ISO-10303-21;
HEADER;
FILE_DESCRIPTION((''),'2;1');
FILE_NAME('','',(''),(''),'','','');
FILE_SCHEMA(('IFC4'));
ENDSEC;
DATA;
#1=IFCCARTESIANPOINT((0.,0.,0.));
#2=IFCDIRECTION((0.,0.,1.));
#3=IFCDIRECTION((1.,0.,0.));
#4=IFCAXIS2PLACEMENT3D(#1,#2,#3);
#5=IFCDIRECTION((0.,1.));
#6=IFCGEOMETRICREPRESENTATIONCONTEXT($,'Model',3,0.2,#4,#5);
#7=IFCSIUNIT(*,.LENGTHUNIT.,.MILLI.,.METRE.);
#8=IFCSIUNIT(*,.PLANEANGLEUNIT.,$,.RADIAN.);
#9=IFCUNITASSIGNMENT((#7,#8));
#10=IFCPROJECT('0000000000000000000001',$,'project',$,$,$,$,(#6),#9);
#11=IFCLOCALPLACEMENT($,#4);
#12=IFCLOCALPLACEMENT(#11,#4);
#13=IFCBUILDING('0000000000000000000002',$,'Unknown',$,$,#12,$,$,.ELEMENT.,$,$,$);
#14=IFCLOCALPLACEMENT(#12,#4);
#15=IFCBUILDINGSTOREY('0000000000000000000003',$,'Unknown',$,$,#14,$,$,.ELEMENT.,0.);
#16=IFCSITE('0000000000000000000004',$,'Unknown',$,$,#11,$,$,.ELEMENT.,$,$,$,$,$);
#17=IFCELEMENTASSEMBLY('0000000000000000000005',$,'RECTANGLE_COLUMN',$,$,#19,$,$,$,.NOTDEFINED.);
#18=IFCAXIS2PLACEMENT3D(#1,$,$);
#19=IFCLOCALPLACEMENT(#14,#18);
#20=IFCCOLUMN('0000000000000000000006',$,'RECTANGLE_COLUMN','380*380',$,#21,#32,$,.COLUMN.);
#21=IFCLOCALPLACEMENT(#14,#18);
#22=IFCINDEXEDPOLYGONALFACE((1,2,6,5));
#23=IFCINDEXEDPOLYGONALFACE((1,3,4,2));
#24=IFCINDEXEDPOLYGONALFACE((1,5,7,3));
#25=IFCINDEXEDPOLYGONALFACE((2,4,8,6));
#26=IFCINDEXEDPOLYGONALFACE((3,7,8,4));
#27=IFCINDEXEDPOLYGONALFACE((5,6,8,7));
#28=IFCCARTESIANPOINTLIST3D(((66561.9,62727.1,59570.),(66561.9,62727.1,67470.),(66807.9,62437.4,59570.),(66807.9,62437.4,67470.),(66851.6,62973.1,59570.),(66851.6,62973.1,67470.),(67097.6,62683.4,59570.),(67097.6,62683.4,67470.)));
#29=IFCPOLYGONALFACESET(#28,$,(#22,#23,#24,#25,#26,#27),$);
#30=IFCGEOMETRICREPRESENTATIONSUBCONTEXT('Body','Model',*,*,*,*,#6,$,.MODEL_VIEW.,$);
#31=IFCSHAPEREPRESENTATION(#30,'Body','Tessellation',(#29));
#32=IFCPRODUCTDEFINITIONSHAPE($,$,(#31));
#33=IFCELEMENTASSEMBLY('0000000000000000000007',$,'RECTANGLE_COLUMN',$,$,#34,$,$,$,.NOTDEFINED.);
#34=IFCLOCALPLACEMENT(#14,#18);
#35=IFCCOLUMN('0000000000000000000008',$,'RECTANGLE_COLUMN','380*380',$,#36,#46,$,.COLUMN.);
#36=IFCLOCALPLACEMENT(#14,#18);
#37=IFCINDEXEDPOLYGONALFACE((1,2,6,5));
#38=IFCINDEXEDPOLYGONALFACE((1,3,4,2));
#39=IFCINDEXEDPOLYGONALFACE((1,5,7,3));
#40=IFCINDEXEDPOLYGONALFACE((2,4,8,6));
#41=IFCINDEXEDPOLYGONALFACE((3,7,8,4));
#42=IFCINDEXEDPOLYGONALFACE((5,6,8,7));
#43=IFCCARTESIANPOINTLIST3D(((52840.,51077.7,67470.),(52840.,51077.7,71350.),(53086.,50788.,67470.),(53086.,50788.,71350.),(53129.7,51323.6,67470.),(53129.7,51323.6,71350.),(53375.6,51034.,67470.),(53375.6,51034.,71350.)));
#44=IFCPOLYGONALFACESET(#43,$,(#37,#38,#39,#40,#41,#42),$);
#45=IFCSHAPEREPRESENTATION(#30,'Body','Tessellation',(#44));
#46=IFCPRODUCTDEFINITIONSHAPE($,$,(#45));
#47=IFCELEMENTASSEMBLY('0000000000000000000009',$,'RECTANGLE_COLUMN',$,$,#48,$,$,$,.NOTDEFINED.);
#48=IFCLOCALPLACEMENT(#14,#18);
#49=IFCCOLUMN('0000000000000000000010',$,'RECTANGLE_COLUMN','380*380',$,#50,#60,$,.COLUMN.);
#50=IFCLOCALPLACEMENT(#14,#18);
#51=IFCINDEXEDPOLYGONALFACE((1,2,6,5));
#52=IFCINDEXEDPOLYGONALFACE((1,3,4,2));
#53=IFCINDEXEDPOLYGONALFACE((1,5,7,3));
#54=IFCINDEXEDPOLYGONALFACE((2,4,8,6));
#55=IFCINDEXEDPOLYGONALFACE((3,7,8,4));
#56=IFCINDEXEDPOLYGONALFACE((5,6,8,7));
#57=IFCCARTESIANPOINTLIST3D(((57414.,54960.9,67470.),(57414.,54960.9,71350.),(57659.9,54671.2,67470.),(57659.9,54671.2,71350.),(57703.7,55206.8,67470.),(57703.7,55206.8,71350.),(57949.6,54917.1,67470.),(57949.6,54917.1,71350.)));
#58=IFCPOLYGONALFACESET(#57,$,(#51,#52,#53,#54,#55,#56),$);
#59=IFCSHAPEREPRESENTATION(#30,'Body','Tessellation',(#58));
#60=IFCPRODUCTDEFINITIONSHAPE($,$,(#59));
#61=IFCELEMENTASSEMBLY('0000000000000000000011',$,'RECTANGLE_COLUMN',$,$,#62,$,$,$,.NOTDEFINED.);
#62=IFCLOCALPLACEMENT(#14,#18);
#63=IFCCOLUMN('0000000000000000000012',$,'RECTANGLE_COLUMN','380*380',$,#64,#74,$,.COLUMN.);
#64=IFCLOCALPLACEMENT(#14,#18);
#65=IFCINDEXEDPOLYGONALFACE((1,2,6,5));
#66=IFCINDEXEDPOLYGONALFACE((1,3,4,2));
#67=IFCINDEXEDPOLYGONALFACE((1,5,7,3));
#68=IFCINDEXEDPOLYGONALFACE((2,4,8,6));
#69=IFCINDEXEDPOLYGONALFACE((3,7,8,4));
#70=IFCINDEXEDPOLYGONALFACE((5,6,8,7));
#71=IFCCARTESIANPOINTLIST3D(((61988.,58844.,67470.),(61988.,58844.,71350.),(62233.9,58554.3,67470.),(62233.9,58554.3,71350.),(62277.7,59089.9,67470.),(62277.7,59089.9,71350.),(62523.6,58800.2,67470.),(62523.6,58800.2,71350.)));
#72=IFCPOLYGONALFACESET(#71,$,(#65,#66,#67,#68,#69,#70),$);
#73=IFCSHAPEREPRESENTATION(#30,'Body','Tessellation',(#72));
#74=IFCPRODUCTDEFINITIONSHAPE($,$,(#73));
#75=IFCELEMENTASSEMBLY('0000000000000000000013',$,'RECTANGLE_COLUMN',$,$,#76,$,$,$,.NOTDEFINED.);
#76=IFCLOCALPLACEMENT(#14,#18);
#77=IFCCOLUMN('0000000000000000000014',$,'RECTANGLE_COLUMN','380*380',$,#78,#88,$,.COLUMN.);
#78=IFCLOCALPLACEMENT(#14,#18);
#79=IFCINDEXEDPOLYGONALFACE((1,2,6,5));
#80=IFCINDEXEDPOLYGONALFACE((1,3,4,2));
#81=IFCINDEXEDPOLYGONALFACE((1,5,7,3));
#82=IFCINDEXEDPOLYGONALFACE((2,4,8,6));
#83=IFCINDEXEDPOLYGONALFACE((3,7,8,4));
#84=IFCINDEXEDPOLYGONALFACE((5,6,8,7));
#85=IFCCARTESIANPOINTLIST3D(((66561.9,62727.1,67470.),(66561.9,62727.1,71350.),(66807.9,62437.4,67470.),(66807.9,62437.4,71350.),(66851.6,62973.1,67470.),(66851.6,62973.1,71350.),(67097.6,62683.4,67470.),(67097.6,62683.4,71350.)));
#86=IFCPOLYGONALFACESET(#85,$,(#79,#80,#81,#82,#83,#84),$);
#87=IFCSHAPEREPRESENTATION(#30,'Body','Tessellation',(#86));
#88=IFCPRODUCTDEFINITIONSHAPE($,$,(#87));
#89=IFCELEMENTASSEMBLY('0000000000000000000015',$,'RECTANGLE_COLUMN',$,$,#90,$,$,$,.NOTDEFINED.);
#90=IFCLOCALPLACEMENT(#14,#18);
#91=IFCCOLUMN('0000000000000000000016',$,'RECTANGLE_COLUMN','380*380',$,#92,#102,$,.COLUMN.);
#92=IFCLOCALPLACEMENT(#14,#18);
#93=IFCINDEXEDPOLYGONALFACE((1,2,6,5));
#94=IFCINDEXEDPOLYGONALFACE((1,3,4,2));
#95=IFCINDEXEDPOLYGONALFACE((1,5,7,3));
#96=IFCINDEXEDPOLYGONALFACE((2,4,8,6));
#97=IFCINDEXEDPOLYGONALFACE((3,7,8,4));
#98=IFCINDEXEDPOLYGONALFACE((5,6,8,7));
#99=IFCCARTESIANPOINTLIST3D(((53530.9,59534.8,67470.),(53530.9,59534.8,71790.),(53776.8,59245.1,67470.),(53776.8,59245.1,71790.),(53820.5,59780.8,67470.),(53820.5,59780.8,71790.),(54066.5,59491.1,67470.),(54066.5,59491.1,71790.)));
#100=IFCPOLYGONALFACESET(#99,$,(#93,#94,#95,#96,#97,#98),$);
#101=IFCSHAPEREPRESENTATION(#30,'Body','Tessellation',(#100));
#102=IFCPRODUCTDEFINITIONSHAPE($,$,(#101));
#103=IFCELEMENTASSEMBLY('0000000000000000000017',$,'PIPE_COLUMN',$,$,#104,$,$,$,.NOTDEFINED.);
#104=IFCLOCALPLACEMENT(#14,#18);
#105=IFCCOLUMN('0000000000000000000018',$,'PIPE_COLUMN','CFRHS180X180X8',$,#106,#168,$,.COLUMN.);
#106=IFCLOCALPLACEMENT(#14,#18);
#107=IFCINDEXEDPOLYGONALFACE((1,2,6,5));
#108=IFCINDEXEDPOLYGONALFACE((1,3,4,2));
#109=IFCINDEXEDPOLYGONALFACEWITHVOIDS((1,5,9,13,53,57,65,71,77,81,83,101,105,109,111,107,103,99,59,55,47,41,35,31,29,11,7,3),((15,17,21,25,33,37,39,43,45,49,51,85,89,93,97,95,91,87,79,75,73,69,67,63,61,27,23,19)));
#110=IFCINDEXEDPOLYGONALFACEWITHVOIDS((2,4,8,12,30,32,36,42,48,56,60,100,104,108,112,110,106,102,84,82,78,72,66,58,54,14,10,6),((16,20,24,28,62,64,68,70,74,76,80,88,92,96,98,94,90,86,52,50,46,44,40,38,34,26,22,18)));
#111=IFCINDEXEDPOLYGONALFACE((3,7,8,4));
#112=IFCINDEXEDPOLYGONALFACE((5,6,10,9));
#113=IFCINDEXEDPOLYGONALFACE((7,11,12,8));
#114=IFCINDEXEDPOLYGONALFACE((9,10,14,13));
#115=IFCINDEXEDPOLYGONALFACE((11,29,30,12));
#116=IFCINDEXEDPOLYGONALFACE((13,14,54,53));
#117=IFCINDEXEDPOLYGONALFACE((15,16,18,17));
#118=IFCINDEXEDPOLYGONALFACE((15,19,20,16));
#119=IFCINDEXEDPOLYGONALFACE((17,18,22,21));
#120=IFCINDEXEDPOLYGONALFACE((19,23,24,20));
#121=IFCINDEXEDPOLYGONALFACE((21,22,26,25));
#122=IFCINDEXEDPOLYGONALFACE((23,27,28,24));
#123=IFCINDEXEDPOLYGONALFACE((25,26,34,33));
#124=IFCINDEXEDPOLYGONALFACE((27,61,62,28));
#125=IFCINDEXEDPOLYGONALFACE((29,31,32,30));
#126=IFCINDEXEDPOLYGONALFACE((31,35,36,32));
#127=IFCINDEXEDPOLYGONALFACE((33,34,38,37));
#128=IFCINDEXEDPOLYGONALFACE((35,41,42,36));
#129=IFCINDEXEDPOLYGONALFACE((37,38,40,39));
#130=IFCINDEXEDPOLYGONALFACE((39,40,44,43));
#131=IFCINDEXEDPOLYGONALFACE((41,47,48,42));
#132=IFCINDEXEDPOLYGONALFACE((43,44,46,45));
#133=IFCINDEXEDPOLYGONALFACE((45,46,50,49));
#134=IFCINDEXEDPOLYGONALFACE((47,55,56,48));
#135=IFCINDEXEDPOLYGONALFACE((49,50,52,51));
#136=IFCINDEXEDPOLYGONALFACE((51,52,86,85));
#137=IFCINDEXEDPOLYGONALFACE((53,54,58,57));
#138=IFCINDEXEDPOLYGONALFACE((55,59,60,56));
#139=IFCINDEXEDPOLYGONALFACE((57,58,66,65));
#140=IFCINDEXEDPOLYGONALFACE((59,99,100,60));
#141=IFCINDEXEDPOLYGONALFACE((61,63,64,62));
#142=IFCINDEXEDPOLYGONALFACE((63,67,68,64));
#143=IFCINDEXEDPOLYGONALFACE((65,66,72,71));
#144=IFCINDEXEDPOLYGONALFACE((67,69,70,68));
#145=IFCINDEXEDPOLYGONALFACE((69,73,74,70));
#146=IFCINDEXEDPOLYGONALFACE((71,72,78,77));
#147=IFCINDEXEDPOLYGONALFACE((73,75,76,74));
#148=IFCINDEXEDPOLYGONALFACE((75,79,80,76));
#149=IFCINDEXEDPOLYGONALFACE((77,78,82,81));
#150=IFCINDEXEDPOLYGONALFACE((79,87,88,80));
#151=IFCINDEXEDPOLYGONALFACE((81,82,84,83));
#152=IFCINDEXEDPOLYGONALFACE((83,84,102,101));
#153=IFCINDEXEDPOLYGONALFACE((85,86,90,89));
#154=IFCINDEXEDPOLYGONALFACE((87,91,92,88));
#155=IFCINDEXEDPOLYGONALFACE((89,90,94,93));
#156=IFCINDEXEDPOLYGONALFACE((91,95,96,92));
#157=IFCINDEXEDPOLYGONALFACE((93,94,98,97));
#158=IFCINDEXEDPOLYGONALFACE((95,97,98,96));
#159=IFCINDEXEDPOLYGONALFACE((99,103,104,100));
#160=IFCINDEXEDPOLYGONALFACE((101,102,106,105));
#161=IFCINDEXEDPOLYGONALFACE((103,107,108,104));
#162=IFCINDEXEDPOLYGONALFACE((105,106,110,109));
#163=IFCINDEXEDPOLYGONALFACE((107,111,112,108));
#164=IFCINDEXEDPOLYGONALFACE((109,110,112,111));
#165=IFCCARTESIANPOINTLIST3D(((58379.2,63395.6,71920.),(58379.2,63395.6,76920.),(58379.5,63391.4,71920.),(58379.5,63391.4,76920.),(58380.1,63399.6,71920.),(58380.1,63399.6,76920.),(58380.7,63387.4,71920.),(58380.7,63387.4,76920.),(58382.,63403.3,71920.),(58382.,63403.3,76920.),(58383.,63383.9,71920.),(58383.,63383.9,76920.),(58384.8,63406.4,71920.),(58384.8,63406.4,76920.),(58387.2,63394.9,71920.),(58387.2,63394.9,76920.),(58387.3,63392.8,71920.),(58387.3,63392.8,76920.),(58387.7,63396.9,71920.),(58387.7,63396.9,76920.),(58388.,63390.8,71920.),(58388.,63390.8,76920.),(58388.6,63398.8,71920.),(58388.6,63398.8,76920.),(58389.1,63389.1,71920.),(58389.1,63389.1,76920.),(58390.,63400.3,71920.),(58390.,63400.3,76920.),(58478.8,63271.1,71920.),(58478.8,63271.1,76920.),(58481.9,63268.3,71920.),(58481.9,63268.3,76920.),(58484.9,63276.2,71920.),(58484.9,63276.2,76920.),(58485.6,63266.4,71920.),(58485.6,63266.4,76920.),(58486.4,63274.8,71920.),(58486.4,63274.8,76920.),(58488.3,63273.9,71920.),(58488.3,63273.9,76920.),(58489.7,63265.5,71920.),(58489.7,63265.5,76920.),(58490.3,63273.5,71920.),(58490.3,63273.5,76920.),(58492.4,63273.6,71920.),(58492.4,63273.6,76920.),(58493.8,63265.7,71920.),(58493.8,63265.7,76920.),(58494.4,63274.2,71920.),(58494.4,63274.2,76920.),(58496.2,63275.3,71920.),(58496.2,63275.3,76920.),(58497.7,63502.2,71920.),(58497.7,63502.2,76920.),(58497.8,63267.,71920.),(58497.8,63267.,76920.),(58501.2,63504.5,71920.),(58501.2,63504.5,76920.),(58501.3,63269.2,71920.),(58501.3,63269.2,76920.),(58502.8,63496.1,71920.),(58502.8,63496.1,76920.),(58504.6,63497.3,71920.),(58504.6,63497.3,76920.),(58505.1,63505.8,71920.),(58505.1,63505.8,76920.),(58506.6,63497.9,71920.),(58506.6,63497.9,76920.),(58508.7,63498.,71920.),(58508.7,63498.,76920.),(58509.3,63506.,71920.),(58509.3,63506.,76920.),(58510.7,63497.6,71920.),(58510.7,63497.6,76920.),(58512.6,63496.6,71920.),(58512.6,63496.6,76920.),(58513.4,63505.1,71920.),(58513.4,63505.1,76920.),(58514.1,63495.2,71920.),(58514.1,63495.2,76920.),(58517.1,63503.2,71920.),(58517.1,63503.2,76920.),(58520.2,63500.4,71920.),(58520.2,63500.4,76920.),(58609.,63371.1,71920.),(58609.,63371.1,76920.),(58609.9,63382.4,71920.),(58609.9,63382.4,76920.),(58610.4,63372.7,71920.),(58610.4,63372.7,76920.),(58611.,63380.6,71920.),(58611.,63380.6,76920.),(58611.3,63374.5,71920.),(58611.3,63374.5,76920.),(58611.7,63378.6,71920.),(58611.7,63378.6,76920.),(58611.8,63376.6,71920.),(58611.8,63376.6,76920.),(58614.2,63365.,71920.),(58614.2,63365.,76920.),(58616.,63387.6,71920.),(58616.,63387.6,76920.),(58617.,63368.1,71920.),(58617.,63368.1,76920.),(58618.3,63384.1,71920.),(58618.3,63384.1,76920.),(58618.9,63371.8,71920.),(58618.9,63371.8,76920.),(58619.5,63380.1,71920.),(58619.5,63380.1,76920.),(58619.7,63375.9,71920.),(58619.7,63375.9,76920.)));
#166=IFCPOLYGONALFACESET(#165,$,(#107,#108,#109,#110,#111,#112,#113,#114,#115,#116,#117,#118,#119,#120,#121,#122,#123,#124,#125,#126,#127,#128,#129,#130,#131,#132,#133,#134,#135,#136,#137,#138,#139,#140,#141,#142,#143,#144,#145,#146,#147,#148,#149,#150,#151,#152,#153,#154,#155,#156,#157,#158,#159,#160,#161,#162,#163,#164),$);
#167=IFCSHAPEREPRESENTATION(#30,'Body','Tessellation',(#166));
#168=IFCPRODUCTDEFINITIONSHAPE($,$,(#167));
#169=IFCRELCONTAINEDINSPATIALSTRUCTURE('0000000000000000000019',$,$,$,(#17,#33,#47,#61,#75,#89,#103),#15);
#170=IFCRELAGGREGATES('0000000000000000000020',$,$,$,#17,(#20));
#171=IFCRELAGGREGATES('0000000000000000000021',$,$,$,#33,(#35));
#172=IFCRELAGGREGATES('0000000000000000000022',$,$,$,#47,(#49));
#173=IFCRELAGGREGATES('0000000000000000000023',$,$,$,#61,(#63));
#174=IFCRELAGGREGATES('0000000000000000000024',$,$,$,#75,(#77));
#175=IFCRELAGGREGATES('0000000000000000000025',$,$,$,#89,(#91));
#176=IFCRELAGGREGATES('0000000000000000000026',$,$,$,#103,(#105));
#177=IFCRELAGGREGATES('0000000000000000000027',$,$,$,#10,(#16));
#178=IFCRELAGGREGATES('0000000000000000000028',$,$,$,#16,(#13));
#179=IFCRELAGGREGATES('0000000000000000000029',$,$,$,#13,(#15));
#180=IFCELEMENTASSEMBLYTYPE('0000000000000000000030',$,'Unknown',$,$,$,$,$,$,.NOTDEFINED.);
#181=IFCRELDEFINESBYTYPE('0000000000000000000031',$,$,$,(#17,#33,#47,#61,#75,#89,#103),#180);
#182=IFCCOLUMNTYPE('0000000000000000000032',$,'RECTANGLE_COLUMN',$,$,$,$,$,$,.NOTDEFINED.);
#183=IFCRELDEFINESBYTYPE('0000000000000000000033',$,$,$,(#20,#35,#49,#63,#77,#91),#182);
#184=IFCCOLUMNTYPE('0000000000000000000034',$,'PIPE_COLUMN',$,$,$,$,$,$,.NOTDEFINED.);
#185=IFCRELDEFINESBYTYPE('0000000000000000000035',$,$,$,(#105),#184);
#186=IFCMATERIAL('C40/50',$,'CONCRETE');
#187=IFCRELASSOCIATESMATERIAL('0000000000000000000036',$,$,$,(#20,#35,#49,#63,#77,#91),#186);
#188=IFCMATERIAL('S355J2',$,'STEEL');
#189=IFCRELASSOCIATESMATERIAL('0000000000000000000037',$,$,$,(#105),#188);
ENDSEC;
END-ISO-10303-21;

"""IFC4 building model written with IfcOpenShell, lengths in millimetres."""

from ifc_helpers import new_model, si_unit, direction, frame, origin_with_axes, origin_2d_with_axis, place, context, subcontext, project, spatial, rectangle, hollow_rectangle, extrude, material, material_profile, profile_set, profile_usage, type_object, element, aggregate, save


model = new_model("IFC4")

# Units and contexts
model_context = context("Model", 3, precision=0.2, world=origin_with_axes(), true_north=direction((0.0, 1.0)))
body_context = subcontext(model_context, "Body", "Model", "MODEL_VIEW")
ifc_project = project(units=[si_unit("LENGTHUNIT", "METRE", prefix="MILLI"), si_unit("PLANEANGLEUNIT", "RADIAN")], contexts=[model_context])

# Site, building, storey
site_placement = place(None, origin_with_axes())
site = spatial("IfcSite", under=ifc_project, at=site_placement, Name="Unknown", CompositionType="ELEMENT")
building_placement = place(site_placement, origin_with_axes())
building = spatial("IfcBuilding", under=site, at=building_placement, Name="Unknown", CompositionType="ELEMENT")
storey_placement = place(building_placement, origin_with_axes())
storey = spatial("IfcBuildingStorey", under=building, at=storey_placement, Name="Unknown", CompositionType="ELEMENT", Elevation=0.0)

# Element assemblies, columns
element_assembly_type = type_object("IfcElementAssemblyType", Name="Unknown", PredefinedType="NOTDEFINED")
assembly_1_placement = place(storey_placement, frame((66829.8, 62705.3, 59570.0), z_axis=(-0.762329, -0.64719, 0.0), x_axis=(0.0, 0.0, 1.0)))
assembly_1 = element("IfcElementAssembly", 1, at=assembly_1_placement, inside=storey, type_object=element_assembly_type, Name="RECTANGLE_COLUMN", PredefinedType="NOTDEFINED")
ifc_material_1 = material(Name="C40/50", Category="CONCRETE")
ifc_material_profile_1 = material_profile(ifc_material_1, rectangle(XDim=380.0, YDim=380.0, at=origin_2d_with_axis()), Name="380*380")
ifc_profile_set_1 = profile_set([ifc_material_profile_1])
ifc_profile_usage_1 = profile_usage(ifc_profile_set_1, cardinal=5)
column_type_1 = type_object("IfcColumnType", Name="RECTANGLE_COLUMN")
column_1_placement = place(assembly_1_placement, origin_with_axes())
column_1 = element("IfcColumn", 2, at=column_1_placement, type_object=column_type_1, material=ifc_profile_usage_1, Name="RECTANGLE_COLUMN", Description="380*380", PredefinedType="COLUMN", context=body_context, shape_type="SolidModel", body=[
    extrude(rectangle(XDim=380.0, YDim=380.0, at=origin_2d_with_axis()), frame((0.0, 0.0, 0.0), z_axis=(-1.0, 0.0, 0.0), x_axis=(0.0, 0.0, 1.0)), (0.0, 0.0, -1.0), 7900.0),
])
aggregate(assembly_1, [column_1])
assembly_2_placement = place(storey_placement, frame((53107.8, 51055.8, 67470.0), z_axis=(-0.762329, -0.64719, 0.0), x_axis=(0.0, 0.0, 1.0)))
assembly_2 = element("IfcElementAssembly", 3, at=assembly_2_placement, inside=storey, type_object=element_assembly_type, Name="RECTANGLE_COLUMN", PredefinedType="NOTDEFINED")
column_2_placement = place(assembly_2_placement, origin_with_axes())
column_2 = element("IfcColumn", 4, at=column_2_placement, type_object=column_type_1, material=ifc_profile_usage_1, Name="RECTANGLE_COLUMN", Description="380*380", PredefinedType="COLUMN", context=body_context, shape_type="SolidModel", body=[
    extrude(rectangle(XDim=380.0, YDim=380.0, at=origin_2d_with_axis()), frame((0.0, 0.0, 0.0), z_axis=(-1.0, 0.0, 0.0), x_axis=(0.0, 0.0, 1.0)), (0.0, 0.0, -1.0), 3880.0),
])
aggregate(assembly_2, [column_2])
assembly_3_placement = place(storey_placement, frame((57681.8, 54939.0, 67470.0), z_axis=(-0.762329, -0.64719, 0.0), x_axis=(0.0, 0.0, 1.0)))
assembly_3 = element("IfcElementAssembly", 5, at=assembly_3_placement, inside=storey, type_object=element_assembly_type, Name="RECTANGLE_COLUMN", PredefinedType="NOTDEFINED")
column_3_placement = place(assembly_3_placement, origin_with_axes())
column_3 = element("IfcColumn", 6, at=column_3_placement, type_object=column_type_1, material=ifc_profile_usage_1, Name="RECTANGLE_COLUMN", Description="380*380", PredefinedType="COLUMN", context=body_context, shape_type="SolidModel", body=[
    extrude(rectangle(XDim=380.0, YDim=380.0, at=origin_2d_with_axis()), frame((0.0, 0.0, 0.0), z_axis=(-1.0, 0.0, 0.0), x_axis=(0.0, 0.0, 1.0)), (0.0, 0.0, -1.0), 3880.0),
])
aggregate(assembly_3, [column_3])
assembly_4_placement = place(storey_placement, frame((62255.8, 58822.1, 67470.0), z_axis=(-0.762329, -0.64719, 0.0), x_axis=(0.0, 0.0, 1.0)))
assembly_4 = element("IfcElementAssembly", 7, at=assembly_4_placement, inside=storey, type_object=element_assembly_type, Name="RECTANGLE_COLUMN", PredefinedType="NOTDEFINED")
column_4_placement = place(assembly_4_placement, origin_with_axes())
column_4 = element("IfcColumn", 8, at=column_4_placement, type_object=column_type_1, material=ifc_profile_usage_1, Name="RECTANGLE_COLUMN", Description="380*380", PredefinedType="COLUMN", context=body_context, shape_type="SolidModel", body=[
    extrude(rectangle(XDim=380.0, YDim=380.0, at=origin_2d_with_axis()), frame((0.0, 0.0, 0.0), z_axis=(-1.0, 0.0, 0.0), x_axis=(0.0, 0.0, 1.0)), (0.0, 0.0, -1.0), 3880.0),
])
aggregate(assembly_4, [column_4])
assembly_5_placement = place(storey_placement, frame((66829.8, 62705.3, 67470.0), z_axis=(-0.762329, -0.64719, 0.0), x_axis=(0.0, 0.0, 1.0)))
assembly_5 = element("IfcElementAssembly", 9, at=assembly_5_placement, inside=storey, type_object=element_assembly_type, Name="RECTANGLE_COLUMN", PredefinedType="NOTDEFINED")
column_5_placement = place(assembly_5_placement, origin_with_axes())
column_5 = element("IfcColumn", 10, at=column_5_placement, type_object=column_type_1, material=ifc_profile_usage_1, Name="RECTANGLE_COLUMN", Description="380*380", PredefinedType="COLUMN", context=body_context, shape_type="SolidModel", body=[
    extrude(rectangle(XDim=380.0, YDim=380.0, at=origin_2d_with_axis()), frame((0.0, 0.0, 0.0), z_axis=(-1.0, 0.0, 0.0), x_axis=(0.0, 0.0, 1.0)), (0.0, 0.0, -1.0), 3880.0),
])
aggregate(assembly_5, [column_5])
assembly_6_placement = place(storey_placement, frame((53798.7, 59513.0, 67470.0), z_axis=(-0.762329, -0.64719, 0.0), x_axis=(0.0, 0.0, 1.0)))
assembly_6 = element("IfcElementAssembly", 11, at=assembly_6_placement, inside=storey, type_object=element_assembly_type, Name="RECTANGLE_COLUMN", PredefinedType="NOTDEFINED")
column_6_placement = place(assembly_6_placement, origin_with_axes())
column_6 = element("IfcColumn", 12, at=column_6_placement, type_object=column_type_1, material=ifc_profile_usage_1, Name="RECTANGLE_COLUMN", Description="380*380", PredefinedType="COLUMN", context=body_context, shape_type="SolidModel", body=[
    extrude(rectangle(XDim=380.0, YDim=380.0, at=origin_2d_with_axis()), frame((0.0, 0.0, 0.0), z_axis=(-1.0, 0.0, 0.0), x_axis=(0.0, 0.0, 1.0)), (0.0, 0.0, -1.0), 4320.0),
])
aggregate(assembly_6, [column_6])
assembly_7_placement = place(storey_placement, frame((58499.5, 63385.7, 71920.0), z_axis=(-0.762329, -0.64719, 0.0), x_axis=(0.0, 0.0, 1.0)))
assembly_7 = element("IfcElementAssembly", 13, at=assembly_7_placement, inside=storey, type_object=element_assembly_type, Name="PIPE_COLUMN", PredefinedType="NOTDEFINED")
ifc_material_2 = material(Name="S355J2", Category="STEEL")
ifc_material_profile_2 = material_profile(ifc_material_2, hollow_rectangle(XDim=180.0, YDim=180.0, WallThickness=8.0, InnerFilletRadius=8.0, OuterFilletRadius=16.0, at=origin_2d_with_axis()), Name="CFRHS180X180X8")
ifc_profile_set_2 = profile_set([ifc_material_profile_2])
ifc_profile_usage_2 = profile_usage(ifc_profile_set_2, cardinal=7)
column_type_2 = type_object("IfcColumnType", Name="PIPE_COLUMN")
column_7_placement = place(assembly_7_placement, origin_with_axes())
column_7 = element("IfcColumn", 14, at=column_7_placement, type_object=column_type_2, material=ifc_profile_usage_2, Name="PIPE_COLUMN", Description="CFRHS180X180X8", PredefinedType="COLUMN", context=body_context, shape_type="SolidModel", body=[
    extrude(hollow_rectangle(XDim=180.0, YDim=180.0, WallThickness=8.0, InnerFilletRadius=8.0, OuterFilletRadius=16.0, at=origin_2d_with_axis()), frame((0.0, 0.0, 0.0), z_axis=(-1.0, 0.0, 0.0), x_axis=(0.0, 0.0, 1.0)), (0.0, 0.0, -1.0), 5000.0),
])
aggregate(assembly_7, [column_7])

save(model, "model.ifc")
